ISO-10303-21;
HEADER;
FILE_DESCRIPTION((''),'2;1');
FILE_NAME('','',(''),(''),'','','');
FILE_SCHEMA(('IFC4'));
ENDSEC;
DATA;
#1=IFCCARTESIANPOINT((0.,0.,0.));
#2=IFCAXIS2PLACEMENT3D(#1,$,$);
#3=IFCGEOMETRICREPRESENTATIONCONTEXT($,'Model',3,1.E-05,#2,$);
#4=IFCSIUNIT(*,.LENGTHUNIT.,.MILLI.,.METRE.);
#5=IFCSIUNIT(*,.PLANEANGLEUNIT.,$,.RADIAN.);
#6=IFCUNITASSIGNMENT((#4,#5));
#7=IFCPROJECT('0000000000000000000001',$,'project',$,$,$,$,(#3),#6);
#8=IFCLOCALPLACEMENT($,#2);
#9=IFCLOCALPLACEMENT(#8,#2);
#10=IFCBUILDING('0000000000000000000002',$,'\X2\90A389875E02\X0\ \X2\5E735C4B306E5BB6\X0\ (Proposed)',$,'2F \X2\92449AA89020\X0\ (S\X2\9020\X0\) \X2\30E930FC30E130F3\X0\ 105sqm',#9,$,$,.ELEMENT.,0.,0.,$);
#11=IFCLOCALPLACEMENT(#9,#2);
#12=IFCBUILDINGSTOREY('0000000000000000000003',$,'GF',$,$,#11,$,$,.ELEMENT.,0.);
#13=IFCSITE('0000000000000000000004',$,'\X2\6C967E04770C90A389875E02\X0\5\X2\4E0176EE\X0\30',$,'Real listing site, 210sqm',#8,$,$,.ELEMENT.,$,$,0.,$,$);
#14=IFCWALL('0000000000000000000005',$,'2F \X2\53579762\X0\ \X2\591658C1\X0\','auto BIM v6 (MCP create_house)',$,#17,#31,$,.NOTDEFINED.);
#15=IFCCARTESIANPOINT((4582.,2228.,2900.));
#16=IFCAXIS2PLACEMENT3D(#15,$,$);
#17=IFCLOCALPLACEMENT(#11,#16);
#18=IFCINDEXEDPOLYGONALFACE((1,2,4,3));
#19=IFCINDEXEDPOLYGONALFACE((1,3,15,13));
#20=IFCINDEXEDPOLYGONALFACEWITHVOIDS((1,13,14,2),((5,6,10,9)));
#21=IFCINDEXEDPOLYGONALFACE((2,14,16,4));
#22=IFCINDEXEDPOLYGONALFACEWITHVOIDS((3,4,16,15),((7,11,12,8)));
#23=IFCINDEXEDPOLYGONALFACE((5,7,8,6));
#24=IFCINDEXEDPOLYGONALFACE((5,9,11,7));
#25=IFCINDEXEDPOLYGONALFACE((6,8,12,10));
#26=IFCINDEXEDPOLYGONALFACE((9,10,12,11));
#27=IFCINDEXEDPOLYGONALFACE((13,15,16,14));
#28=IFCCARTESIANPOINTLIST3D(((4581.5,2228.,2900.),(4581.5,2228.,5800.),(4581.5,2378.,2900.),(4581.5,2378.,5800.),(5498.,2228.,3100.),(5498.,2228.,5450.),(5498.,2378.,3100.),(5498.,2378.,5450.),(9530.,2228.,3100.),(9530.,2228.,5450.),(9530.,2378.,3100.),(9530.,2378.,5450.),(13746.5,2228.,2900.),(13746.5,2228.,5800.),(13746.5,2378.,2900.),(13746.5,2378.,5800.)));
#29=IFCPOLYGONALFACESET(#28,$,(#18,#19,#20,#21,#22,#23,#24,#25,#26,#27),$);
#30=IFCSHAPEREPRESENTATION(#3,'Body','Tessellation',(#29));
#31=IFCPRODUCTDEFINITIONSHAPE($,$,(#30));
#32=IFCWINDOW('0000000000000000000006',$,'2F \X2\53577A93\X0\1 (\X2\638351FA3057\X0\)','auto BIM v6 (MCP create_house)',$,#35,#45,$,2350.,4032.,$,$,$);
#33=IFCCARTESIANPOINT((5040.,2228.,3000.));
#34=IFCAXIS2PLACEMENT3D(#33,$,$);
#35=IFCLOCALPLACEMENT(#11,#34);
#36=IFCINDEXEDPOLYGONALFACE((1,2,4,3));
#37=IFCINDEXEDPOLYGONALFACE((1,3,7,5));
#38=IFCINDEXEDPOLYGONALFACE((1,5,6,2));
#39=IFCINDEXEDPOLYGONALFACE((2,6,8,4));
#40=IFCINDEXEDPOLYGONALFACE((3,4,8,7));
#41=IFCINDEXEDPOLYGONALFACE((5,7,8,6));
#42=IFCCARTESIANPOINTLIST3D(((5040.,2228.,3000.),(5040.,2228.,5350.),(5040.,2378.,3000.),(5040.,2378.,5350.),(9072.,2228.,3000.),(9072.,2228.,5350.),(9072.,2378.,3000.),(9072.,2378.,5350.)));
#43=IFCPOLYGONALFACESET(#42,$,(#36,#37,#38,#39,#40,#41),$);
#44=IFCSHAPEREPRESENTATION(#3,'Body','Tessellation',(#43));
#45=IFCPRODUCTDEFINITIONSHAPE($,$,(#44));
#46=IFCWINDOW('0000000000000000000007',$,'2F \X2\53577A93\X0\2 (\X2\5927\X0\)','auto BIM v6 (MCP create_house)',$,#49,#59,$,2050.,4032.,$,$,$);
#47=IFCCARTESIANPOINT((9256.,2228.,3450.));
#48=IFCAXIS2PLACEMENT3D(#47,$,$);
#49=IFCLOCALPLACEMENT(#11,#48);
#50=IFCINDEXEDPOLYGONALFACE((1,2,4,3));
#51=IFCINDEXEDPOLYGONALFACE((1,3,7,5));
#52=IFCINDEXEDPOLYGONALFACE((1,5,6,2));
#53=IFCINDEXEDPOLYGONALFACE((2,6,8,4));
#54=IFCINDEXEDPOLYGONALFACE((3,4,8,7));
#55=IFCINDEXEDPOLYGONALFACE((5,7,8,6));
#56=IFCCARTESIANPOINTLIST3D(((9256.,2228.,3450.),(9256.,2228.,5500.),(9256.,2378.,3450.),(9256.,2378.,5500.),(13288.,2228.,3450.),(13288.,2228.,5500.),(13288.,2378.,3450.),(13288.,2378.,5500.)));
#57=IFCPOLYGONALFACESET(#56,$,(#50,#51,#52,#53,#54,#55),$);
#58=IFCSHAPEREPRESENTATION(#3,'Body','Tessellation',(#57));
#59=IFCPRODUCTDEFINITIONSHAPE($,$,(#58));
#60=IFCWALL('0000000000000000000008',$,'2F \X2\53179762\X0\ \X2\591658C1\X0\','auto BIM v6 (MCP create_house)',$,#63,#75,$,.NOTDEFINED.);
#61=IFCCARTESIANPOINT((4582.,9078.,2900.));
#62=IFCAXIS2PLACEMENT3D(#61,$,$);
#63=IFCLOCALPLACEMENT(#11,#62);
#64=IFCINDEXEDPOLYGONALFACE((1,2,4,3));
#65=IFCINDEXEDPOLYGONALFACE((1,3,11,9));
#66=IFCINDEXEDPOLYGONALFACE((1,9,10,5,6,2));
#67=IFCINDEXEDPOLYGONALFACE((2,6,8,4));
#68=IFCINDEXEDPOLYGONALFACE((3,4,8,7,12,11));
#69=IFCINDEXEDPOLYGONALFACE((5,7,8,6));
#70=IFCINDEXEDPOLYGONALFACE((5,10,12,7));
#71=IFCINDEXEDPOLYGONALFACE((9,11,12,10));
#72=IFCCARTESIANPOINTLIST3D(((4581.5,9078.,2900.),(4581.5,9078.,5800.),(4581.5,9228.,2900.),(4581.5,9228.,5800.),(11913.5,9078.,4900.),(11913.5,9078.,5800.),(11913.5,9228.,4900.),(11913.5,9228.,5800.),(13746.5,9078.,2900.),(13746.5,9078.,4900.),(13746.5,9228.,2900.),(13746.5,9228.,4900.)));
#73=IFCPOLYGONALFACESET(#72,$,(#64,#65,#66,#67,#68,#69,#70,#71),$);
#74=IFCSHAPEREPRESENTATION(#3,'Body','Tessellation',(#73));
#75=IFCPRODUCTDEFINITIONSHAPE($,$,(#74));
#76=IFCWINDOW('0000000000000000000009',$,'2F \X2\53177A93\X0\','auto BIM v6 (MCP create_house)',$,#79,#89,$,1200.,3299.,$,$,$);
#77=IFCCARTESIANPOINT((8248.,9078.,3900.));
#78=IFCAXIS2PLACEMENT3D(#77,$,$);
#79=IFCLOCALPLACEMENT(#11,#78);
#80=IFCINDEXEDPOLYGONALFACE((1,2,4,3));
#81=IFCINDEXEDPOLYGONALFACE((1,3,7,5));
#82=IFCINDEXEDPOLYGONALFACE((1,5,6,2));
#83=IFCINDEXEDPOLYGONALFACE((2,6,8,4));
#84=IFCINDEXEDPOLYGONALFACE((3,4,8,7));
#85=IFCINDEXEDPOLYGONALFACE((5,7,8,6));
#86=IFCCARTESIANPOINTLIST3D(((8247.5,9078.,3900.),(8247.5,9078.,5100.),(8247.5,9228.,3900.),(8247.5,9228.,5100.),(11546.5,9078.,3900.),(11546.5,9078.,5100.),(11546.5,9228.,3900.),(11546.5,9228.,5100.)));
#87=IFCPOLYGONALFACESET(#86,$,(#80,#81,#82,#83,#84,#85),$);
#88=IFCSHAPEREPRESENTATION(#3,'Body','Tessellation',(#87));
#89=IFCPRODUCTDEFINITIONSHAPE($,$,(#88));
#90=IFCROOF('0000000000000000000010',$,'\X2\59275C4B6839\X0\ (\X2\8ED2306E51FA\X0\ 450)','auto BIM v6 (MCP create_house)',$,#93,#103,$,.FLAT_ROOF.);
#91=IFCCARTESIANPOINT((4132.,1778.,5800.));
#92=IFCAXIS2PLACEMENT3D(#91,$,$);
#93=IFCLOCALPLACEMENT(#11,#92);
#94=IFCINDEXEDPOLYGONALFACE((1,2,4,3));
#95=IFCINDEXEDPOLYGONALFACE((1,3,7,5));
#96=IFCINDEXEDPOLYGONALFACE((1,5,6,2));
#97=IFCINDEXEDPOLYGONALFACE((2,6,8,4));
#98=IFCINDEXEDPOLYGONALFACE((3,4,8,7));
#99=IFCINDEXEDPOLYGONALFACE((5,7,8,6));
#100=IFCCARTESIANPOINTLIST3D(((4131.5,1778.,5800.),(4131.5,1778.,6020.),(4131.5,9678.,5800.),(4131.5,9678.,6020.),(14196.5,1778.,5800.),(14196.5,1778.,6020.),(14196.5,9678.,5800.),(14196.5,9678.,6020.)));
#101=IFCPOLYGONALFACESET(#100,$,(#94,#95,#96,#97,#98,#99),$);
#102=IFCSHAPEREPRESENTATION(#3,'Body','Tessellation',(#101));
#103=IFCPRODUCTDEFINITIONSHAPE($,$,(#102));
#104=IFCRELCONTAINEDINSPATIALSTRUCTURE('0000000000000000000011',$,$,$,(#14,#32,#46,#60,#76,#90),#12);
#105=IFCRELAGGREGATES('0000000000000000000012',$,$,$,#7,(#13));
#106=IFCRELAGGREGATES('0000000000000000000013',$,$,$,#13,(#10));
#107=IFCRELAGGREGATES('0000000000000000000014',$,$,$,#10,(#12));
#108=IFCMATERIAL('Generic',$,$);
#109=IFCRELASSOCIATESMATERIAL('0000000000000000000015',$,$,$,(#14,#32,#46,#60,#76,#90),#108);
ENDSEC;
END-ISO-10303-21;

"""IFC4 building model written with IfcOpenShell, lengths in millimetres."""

from ifc_helpers import new_model, si_unit, frame, frame_2d, origin, place, context, project, spatial, rectangle, extrude, material, element, fill, save


model = new_model("IFC4")

# Units and contexts
model_context = context("Model", 3, precision=1e-05, world=origin())
ifc_project = project(units=[si_unit("LENGTHUNIT", "METRE", prefix="MILLI"), si_unit("PLANEANGLEUNIT", "RADIAN")], contexts=[model_context])

# Site, building, storey
site_placement = place(None, origin())
site = spatial("IfcSite", under=ifc_project, at=site_placement, Name="沖縄県那覇市5丁目30", ObjectType="Real listing site, 210sqm", CompositionType="ELEMENT", RefElevation=0.0)
building_placement = place(site_placement, origin())
building = spatial("IfcBuilding", under=site, at=building_placement, Name="那覇市 平屋の家 (Proposed)", ObjectType="2F 鉄骨造 (S造) ラーメン 105sqm", CompositionType="ELEMENT", ElevationOfRefHeight=0.0, ElevationOfTerrain=0.0)
storey_placement = place(building_placement, origin())
storey = spatial("IfcBuildingStorey", under=building, at=storey_placement, Name="GF", CompositionType="ELEMENT", Elevation=0.0)

# Shared definitions
ifc_material = material(Name="Generic")

# Wall, openings, windows
wall_1_placement = place(storey_placement, frame((4582.0, 2228.0, 2900.0)))
wall_1 = element("IfcWall", 1, at=wall_1_placement, inside=storey, material=ifc_material, Name="2F 南面 外壁", Description="auto BIM v6 (MCP create_house)", PredefinedType="NOTDEFINED", context=model_context, shape_type="SweptSolid", body=[
    extrude(rectangle(XDim=9165.0, YDim=150.0, at=frame_2d((4582.0, 75.0))), frame((4582.0, 2228.0, 2900.0)), (0.0, 0.0, 1.0), 2900.0),
])
opening_1_placement = place(storey_placement, frame((5040.0, 2228.0, 3000.0)))
opening_1 = element("IfcOpeningElement", 2, at=opening_1_placement, cuts=wall_1, PredefinedType="NOTDEFINED", context=model_context, shape_type="SweptSolid", body=[
    extrude(rectangle(XDim=4032.0, YDim=150.0, at=frame_2d((2016.0, 75.0))), frame((5040.0, 2228.0, 3000.0)), (0.0, 0.0, 1.0), 2350.0),
])
opening_2_placement = place(storey_placement, frame((9256.0, 2228.0, 3450.0)))
opening_2 = element("IfcOpeningElement", 3, at=opening_2_placement, cuts=wall_1, PredefinedType="NOTDEFINED", context=model_context, shape_type="SweptSolid", body=[
    extrude(rectangle(XDim=4032.0, YDim=150.0, at=frame_2d((2016.0, 75.0))), frame((9256.0, 2228.0, 3450.0)), (0.0, 0.0, 1.0), 2050.0),
])
window_1_placement = place(storey_placement, frame((5040.0, 2228.0, 3000.0)))
window_1 = element("IfcWindow", 4, at=window_1_placement, inside=storey, material=ifc_material, Name="2F 南窓1 (掃出し)", Description="auto BIM v6 (MCP create_house)", OverallHeight=2350.0, OverallWidth=4032.0, context=model_context, shape_type="SweptSolid", body=[
    extrude(rectangle(XDim=4032.0, YDim=150.0, at=frame_2d((2016.0, 75.0))), frame((5040.0, 2228.0, 3000.0)), (0.0, 0.0, 1.0), 2350.0),
])
fill(opening_1, window_1)
window_2_placement = place(storey_placement, frame((9256.0, 2228.0, 3450.0)))
window_2 = element("IfcWindow", 5, at=window_2_placement, inside=storey, material=ifc_material, Name="2F 南窓2 (大)", Description="auto BIM v6 (MCP create_house)", OverallHeight=2050.0, OverallWidth=4032.0, context=model_context, shape_type="SweptSolid", body=[
    extrude(rectangle(XDim=4032.0, YDim=150.0, at=frame_2d((2016.0, 75.0))), frame((9256.0, 2228.0, 3450.0)), (0.0, 0.0, 1.0), 2050.0),
])
fill(opening_2, window_2)

# Wall, opening, window
wall_2_placement = place(storey_placement, frame((4582.0, 9078.0, 2900.0)))
wall_2 = element("IfcWall", 6, at=wall_2_placement, inside=storey, material=ifc_material, Name="2F 北面 外壁", Description="auto BIM v6 (MCP create_house)", PredefinedType="NOTDEFINED", context=model_context, shape_type="SweptSolid", body=[
    extrude(rectangle(XDim=9165.0, YDim=150.0, at=frame_2d((4582.0, 75.0))), frame((4582.0, 9078.0, 2900.0)), (0.0, 0.0, 1.0), 2900.0),
])
opening_3_placement = place(storey_placement, frame((8248.0, 9078.0, 3900.0)))
opening_3 = element("IfcOpeningElement", 7, at=opening_3_placement, cuts=wall_2, PredefinedType="NOTDEFINED", context=model_context, shape_type="SweptSolid", body=[
    extrude(rectangle(XDim=3299.0, YDim=150.0, at=frame_2d((1649.0, 75.0))), frame((8248.0, 9078.0, 3900.0)), (0.0, 0.0, 1.0), 1200.0),
])
window_3_placement = place(storey_placement, frame((8248.0, 9078.0, 3900.0)))
window_3 = element("IfcWindow", 8, at=window_3_placement, inside=storey, material=ifc_material, Name="2F 北窓", Description="auto BIM v6 (MCP create_house)", OverallHeight=1200.0, OverallWidth=3299.0, context=model_context, shape_type="SweptSolid", body=[
    extrude(rectangle(XDim=3299.0, YDim=150.0, at=frame_2d((1649.0, 75.0))), frame((8248.0, 9078.0, 3900.0)), (0.0, 0.0, 1.0), 1200.0),
])
fill(opening_3, window_3)

# Roof
roof_placement = place(storey_placement, frame((4132.0, 1778.0, 5800.0)))
element("IfcRoof", 9, at=roof_placement, inside=storey, material=ifc_material, Name="大屋根 (軒の出 450)", Description="auto BIM v6 (MCP create_house)", PredefinedType="FLAT_ROOF", context=model_context, shape_type="SweptSolid", body=[
    extrude(rectangle(XDim=10065.0, YDim=7900.0, at=frame_2d((5032.0, 3950.0))), frame((4132.0, 1778.0, 5800.0)), (0.0, 0.0, 1.0), 220.0),
])

save(model, "model.ifc")
